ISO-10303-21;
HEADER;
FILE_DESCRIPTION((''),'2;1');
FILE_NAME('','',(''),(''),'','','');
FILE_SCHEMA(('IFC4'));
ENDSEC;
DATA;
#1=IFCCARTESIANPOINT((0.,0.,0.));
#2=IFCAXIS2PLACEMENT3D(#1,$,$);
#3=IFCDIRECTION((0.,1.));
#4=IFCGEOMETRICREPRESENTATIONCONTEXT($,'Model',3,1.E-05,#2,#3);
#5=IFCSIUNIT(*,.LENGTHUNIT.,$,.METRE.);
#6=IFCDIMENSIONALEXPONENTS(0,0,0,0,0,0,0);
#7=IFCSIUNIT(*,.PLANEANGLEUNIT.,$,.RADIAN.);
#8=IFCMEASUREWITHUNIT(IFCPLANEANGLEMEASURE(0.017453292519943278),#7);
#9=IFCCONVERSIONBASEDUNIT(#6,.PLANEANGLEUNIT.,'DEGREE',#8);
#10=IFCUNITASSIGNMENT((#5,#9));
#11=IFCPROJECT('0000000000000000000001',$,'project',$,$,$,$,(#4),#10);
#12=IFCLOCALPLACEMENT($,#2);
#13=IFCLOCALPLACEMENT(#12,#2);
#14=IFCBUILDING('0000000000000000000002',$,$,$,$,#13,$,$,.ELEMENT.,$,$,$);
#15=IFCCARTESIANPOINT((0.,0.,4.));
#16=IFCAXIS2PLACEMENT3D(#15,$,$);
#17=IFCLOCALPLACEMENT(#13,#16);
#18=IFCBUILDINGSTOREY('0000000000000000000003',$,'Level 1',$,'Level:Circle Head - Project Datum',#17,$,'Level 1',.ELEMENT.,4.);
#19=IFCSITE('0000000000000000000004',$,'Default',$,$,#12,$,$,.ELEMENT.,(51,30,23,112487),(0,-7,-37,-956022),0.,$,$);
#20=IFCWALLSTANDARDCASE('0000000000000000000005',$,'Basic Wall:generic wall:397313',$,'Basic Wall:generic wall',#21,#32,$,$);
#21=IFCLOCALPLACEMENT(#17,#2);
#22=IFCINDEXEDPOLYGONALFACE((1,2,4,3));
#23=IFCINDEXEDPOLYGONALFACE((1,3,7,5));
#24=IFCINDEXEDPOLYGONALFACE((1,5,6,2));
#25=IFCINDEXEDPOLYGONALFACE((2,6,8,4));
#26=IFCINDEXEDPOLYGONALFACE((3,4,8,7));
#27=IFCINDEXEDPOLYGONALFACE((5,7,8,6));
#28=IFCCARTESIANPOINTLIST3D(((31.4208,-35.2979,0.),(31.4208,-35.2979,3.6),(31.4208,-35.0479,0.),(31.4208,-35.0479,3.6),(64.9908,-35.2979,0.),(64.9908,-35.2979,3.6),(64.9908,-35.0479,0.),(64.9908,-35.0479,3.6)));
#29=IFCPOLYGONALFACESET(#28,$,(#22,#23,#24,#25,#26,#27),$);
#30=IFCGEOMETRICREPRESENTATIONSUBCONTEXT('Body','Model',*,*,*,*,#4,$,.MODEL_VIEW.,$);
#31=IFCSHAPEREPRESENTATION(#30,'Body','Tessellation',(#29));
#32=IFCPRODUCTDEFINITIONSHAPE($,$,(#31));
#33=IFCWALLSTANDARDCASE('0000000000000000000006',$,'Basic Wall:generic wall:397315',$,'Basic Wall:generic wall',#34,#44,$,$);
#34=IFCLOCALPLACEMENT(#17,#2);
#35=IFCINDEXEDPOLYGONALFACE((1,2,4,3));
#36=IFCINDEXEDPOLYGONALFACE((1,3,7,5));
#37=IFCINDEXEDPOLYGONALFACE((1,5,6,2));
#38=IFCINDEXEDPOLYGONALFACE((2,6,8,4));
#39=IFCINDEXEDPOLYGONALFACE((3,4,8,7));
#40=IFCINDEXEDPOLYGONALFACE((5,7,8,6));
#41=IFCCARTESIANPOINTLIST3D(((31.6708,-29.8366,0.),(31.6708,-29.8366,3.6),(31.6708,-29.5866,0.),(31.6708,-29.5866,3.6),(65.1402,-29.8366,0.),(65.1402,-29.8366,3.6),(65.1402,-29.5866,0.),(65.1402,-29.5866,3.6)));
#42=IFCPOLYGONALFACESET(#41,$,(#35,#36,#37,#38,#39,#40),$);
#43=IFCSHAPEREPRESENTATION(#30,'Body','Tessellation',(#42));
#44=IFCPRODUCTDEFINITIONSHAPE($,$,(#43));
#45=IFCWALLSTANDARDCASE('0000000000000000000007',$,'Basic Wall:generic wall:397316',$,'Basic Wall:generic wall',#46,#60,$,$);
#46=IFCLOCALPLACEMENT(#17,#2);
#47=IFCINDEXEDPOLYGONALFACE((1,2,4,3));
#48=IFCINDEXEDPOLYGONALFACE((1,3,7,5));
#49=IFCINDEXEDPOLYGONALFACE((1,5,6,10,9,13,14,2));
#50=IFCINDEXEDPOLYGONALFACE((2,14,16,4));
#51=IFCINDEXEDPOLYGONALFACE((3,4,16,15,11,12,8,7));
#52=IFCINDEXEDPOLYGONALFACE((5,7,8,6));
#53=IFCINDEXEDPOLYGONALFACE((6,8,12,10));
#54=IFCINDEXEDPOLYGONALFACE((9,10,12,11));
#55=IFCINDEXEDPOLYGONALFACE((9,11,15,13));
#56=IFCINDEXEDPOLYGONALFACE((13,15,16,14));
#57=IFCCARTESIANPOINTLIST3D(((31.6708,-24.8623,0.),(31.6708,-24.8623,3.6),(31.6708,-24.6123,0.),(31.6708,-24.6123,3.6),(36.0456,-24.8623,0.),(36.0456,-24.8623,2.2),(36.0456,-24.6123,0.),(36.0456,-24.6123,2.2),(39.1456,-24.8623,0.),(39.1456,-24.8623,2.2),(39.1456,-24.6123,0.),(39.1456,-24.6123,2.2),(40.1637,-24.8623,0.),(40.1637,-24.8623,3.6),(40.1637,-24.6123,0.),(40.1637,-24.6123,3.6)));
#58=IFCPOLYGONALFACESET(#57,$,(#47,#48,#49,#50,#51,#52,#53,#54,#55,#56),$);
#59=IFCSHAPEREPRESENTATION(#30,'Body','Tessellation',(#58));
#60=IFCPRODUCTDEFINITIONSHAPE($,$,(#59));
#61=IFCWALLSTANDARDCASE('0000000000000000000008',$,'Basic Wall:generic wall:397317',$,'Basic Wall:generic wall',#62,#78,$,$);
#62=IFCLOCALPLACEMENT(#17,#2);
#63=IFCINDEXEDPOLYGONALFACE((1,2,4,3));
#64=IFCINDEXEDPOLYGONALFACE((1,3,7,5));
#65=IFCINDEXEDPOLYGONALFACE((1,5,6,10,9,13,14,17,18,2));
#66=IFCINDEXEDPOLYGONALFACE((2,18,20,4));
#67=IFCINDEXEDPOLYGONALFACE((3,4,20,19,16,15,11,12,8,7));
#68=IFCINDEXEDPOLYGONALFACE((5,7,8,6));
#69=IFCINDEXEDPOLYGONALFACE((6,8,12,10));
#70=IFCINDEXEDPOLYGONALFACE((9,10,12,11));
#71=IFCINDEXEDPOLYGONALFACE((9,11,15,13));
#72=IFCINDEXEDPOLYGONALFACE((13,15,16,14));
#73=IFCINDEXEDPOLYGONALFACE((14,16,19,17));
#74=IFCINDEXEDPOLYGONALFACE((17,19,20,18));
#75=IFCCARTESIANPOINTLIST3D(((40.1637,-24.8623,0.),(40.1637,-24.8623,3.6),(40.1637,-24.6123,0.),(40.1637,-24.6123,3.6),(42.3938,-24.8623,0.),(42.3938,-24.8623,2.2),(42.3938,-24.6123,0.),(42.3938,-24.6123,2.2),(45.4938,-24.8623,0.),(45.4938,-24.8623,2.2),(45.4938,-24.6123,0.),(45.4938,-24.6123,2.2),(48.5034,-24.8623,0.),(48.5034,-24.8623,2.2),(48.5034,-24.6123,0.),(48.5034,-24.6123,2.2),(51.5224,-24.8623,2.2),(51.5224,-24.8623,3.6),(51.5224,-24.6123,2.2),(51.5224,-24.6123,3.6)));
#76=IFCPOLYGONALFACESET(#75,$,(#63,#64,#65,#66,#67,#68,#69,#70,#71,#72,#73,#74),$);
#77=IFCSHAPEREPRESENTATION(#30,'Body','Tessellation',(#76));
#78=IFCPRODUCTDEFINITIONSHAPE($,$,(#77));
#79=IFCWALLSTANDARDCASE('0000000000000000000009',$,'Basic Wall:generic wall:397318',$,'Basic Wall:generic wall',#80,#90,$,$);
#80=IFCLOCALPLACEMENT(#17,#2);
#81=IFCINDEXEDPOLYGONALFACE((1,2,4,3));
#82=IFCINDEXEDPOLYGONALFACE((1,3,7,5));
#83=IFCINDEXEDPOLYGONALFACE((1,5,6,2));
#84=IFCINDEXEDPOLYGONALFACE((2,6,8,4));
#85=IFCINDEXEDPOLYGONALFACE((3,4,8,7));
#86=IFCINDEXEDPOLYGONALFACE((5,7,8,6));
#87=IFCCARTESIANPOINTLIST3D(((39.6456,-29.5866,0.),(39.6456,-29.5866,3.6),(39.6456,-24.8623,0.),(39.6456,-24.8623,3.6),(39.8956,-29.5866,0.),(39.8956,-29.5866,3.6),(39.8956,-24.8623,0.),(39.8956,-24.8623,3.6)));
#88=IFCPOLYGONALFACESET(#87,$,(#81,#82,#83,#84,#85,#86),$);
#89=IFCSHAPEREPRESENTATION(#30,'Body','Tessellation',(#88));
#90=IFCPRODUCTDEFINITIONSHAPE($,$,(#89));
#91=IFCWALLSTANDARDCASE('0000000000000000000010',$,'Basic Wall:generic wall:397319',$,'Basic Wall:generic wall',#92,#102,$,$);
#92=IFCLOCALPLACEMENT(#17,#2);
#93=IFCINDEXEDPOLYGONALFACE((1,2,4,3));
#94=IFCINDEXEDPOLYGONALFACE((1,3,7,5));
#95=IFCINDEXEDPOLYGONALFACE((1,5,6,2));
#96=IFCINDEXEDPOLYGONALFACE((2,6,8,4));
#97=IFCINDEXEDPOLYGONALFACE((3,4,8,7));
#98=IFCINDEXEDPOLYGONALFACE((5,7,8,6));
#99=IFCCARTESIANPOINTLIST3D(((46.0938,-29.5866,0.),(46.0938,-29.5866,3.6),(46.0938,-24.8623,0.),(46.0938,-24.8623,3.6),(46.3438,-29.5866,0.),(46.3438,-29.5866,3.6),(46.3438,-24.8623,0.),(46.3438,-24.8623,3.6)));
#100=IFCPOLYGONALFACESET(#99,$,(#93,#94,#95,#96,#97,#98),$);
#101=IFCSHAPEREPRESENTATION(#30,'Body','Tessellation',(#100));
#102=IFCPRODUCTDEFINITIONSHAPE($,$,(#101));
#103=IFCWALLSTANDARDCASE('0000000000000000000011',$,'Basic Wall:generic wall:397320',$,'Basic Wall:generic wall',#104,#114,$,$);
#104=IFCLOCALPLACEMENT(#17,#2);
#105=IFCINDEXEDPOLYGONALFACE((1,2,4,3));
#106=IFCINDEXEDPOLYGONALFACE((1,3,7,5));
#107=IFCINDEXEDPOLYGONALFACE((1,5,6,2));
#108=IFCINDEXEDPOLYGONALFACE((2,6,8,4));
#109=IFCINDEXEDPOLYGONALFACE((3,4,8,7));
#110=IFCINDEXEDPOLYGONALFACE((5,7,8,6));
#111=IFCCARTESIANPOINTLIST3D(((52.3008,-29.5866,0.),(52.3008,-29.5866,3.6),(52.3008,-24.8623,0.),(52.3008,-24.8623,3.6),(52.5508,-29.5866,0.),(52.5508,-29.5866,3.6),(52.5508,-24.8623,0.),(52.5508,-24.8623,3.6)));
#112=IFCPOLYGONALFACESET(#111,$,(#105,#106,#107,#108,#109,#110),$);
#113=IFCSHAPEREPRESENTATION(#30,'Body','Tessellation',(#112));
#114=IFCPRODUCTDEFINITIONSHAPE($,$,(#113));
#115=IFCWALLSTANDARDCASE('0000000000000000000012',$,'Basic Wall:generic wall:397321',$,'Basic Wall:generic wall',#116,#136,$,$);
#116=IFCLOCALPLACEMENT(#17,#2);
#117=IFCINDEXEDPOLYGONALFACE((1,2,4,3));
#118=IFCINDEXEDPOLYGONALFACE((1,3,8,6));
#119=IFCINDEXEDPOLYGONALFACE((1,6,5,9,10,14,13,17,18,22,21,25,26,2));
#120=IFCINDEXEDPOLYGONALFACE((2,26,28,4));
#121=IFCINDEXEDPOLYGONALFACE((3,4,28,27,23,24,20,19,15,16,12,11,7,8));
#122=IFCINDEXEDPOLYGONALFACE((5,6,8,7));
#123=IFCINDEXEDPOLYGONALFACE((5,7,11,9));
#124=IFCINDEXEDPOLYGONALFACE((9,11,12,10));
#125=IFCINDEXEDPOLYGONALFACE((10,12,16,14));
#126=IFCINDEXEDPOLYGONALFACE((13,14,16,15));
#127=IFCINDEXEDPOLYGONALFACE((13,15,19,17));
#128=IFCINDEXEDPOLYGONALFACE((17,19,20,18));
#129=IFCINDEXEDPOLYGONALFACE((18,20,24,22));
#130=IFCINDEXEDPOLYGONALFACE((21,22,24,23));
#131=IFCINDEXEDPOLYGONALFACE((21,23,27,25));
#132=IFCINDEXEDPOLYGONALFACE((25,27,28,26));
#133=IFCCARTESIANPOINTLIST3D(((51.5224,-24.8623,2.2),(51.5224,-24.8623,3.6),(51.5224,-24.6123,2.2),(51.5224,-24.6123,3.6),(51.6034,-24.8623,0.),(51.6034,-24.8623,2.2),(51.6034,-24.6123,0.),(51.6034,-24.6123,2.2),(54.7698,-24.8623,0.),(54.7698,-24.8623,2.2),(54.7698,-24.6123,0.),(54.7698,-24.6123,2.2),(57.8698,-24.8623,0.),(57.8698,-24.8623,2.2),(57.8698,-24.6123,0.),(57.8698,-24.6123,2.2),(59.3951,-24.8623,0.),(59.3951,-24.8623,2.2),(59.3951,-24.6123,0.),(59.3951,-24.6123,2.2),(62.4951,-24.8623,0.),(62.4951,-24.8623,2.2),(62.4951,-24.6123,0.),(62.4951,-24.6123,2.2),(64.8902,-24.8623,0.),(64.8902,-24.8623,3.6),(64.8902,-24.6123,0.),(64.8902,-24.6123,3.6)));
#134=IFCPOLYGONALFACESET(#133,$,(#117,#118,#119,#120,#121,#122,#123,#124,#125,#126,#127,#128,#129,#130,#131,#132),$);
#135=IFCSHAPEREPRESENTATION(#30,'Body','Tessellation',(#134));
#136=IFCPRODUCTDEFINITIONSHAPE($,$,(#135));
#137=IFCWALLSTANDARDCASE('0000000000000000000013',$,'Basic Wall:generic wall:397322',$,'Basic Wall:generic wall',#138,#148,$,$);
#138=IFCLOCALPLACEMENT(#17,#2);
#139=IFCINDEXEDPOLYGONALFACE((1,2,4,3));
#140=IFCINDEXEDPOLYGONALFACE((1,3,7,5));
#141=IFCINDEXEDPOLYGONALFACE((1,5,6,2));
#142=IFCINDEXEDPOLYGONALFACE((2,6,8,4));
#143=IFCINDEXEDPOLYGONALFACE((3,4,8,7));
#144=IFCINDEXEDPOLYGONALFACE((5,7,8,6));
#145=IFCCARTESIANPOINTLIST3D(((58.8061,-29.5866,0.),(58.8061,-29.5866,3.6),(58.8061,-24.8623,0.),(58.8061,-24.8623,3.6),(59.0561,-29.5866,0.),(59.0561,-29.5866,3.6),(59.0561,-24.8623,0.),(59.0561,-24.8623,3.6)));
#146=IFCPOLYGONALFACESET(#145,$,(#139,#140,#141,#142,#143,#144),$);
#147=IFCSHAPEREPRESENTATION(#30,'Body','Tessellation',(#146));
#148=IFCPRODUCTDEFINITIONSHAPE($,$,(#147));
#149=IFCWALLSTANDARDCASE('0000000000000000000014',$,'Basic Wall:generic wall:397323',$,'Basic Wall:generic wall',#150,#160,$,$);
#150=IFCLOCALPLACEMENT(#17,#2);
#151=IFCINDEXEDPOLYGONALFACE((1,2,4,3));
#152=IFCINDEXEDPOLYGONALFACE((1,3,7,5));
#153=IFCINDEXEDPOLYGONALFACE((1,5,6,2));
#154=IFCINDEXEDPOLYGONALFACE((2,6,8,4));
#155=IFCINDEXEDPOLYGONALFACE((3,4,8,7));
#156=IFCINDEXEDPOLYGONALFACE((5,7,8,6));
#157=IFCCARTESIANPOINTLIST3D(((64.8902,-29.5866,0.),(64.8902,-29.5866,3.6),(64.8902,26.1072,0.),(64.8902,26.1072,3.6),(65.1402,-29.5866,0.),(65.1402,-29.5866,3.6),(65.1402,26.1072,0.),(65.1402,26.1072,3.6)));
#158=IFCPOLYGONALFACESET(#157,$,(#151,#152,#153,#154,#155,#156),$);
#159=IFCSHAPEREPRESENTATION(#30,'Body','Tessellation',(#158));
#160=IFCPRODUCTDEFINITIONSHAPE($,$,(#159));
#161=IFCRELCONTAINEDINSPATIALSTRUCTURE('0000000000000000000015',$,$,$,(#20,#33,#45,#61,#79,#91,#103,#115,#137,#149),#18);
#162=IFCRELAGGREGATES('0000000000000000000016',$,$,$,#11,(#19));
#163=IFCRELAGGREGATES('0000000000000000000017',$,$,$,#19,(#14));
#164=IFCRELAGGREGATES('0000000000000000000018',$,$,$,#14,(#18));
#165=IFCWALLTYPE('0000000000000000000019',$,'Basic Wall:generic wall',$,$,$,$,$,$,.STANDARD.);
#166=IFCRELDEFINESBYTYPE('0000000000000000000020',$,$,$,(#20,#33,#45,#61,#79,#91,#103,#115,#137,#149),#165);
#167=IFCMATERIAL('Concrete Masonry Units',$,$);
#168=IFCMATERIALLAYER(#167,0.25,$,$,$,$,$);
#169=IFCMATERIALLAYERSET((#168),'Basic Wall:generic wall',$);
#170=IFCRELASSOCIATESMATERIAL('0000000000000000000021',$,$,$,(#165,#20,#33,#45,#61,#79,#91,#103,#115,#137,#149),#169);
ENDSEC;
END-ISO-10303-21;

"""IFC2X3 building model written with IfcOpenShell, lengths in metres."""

from ifc_helpers import new_model, entity, si_unit, converted_unit, direction, frame, frame_2d, origin, place, context, subcontext, project, spatial, rectangle, extrude, material, layer, layer_set, layer_usage, type_object, element, save


model = new_model("IFC2X3")

# Units and contexts
model_context = context("Model", 3, precision=1e-05, world=origin(), true_north=direction((0.0, 1.0)))
body_context = subcontext(model_context, "Body", "Model", "MODEL_VIEW")
ifc_project = project(units=[si_unit("LENGTHUNIT", "METRE"), converted_unit("PLANEANGLEUNIT", "DEGREE", entity("IfcPlaneAngleMeasure", 0.017453292519943278), si_unit("PLANEANGLEUNIT", "RADIAN"), dimensions=[0, 0, 0, 0, 0, 0, 0])], contexts=[model_context])

# Site, building, storey
site_placement = place(None, origin())
site = spatial("IfcSite", under=ifc_project, at=site_placement, Name="Default", CompositionType="ELEMENT", RefLatitude=(51, 30, 23, 112487), RefLongitude=(0, -7, -37, -956022), RefElevation=0.0)
building_placement = place(site_placement, origin())
building = spatial("IfcBuilding", under=site, at=building_placement, CompositionType="ELEMENT")
storey_placement = place(building_placement, frame((0.0, 0.0, 4.0)))
storey = spatial("IfcBuildingStorey", under=building, at=storey_placement, Name="Level 1", ObjectType="Level:Circle Head - Project Datum", LongName="Level 1", CompositionType="ELEMENT", Elevation=4.0)

# Shared definitions
ifc_material = material(Name="Concrete Masonry Units")
ifc_layer = layer(ifc_material, 0.25)
ifc_layer_set = layer_set([ifc_layer], Name="Basic Wall:generic wall")
wall_type = type_object("IfcWallType", Name="Basic Wall:generic wall", PredefinedType="STANDARD", material=ifc_layer_set)

# Walls
ifc_layer_usage_1 = layer_usage(ifc_layer_set, "AXIS2", "NEGATIVE", 0.125)
wall_1_placement = place(storey_placement, frame((64.9908, -35.1729, 0.0), z_axis=(0.0, 0.0, 1.0), x_axis=(-1.0, 0.0, 0.0)))
element("IfcWallStandardCase", 1, at=wall_1_placement, inside=storey, type_object=wall_type, material=ifc_layer_usage_1, Name="Basic Wall:generic wall:397313", ObjectType="Basic Wall:generic wall", context=body_context, shape_type="SweptSolid", body=[
    extrude(rectangle(XDim=33.57, YDim=0.25, at=frame_2d((16.785, 0.0), x_axis=(-1.0, 0.0))), origin(), (0.0, 0.0, 1.0), 3.6),
])
ifc_layer_usage_2 = layer_usage(ifc_layer_set, "AXIS2", "NEGATIVE", 0.125)
wall_2_placement = place(storey_placement, frame((31.6708, -29.7116, 0.0)))
element("IfcWallStandardCase", 2, at=wall_2_placement, inside=storey, type_object=wall_type, material=ifc_layer_usage_2, Name="Basic Wall:generic wall:397315", ObjectType="Basic Wall:generic wall", context=body_context, shape_type="SweptSolid", body=[
    extrude(rectangle(XDim=33.4694, YDim=0.25, at=frame_2d((16.7347, 0.0), x_axis=(-1.0, 0.0))), origin(), (0.0, 0.0, 1.0), 3.6),
])

# Wall, opening
ifc_layer_usage_3 = layer_usage(ifc_layer_set, "AXIS2", "NEGATIVE", 0.125)
wall_3_placement = place(storey_placement, frame((31.6708, -24.7373, 0.0)))
wall_3 = element("IfcWallStandardCase", 3, at=wall_3_placement, inside=storey, type_object=wall_type, material=ifc_layer_usage_3, Name="Basic Wall:generic wall:397316", ObjectType="Basic Wall:generic wall", context=body_context, shape_type="SweptSolid", body=[
    extrude(rectangle(XDim=8.4929, YDim=0.25, at=frame_2d((4.2465, 0.0), x_axis=(-1.0, 0.0))), origin(), (0.0, 0.0, 1.0), 3.6),
])
opening_1_placement = place(wall_3_placement, frame((7.4748, 0.125, 0.0)))
element("IfcOpeningElement", 4, at=opening_1_placement, cuts=wall_3, ObjectType="Opening", context=body_context, shape_type="SweptSolid", body=[
    extrude(rectangle(XDim=2.2, YDim=3.1, at=frame_2d((1.1, 1.55), x_axis=(1.0, 0.0))), frame((0.0, 0.0, 0.0), z_axis=(0.0, -1.0, 0.0), x_axis=(0.0, 0.0, 1.0)), (0.0, 0.0, 1.0), 0.25),
])

# Wall, openings
ifc_layer_usage_4 = layer_usage(ifc_layer_set, "AXIS2", "NEGATIVE", 0.125)
wall_4_placement = place(storey_placement, frame((40.1637, -24.7373, 0.0)))
wall_4 = element("IfcWallStandardCase", 5, at=wall_4_placement, inside=storey, type_object=wall_type, material=ifc_layer_usage_4, Name="Basic Wall:generic wall:397317", ObjectType="Basic Wall:generic wall", context=body_context, shape_type="SweptSolid", body=[
    extrude(rectangle(XDim=11.3587, YDim=0.25, at=frame_2d((5.6794, 0.0), x_axis=(-1.0, 0.0))), origin(), (0.0, 0.0, 1.0), 3.6),
])
opening_2_placement = place(wall_4_placement, frame((11.4397, 0.125, 0.0)))
element("IfcOpeningElement", 6, at=opening_2_placement, cuts=wall_4, ObjectType="Opening", context=body_context, shape_type="SweptSolid", body=[
    extrude(rectangle(XDim=2.2, YDim=3.1, at=frame_2d((1.1, 1.55), x_axis=(1.0, 0.0))), frame((0.0, 0.0, 0.0), z_axis=(0.0, -1.0, 0.0), x_axis=(0.0, 0.0, 1.0)), (0.0, 0.0, 1.0), 0.25),
])
opening_3_placement = place(wall_4_placement, frame((5.3301, 0.125, 0.0)))
element("IfcOpeningElement", 7, at=opening_3_placement, cuts=wall_4, ObjectType="Opening", context=body_context, shape_type="SweptSolid", body=[
    extrude(rectangle(XDim=2.2, YDim=3.1, at=frame_2d((1.1, 1.55), x_axis=(1.0, 0.0))), frame((0.0, 0.0, 0.0), z_axis=(0.0, -1.0, 0.0), x_axis=(0.0, 0.0, 1.0)), (0.0, 0.0, 1.0), 0.25),
])

# Walls
ifc_layer_usage_5 = layer_usage(ifc_layer_set, "AXIS2", "NEGATIVE", 0.125)
wall_5_placement = place(storey_placement, frame((39.7706, -24.8623, 0.0), z_axis=(0.0, 0.0, 1.0), x_axis=(0.0, -1.0, 0.0)))
element("IfcWallStandardCase", 8, at=wall_5_placement, inside=storey, type_object=wall_type, material=ifc_layer_usage_5, Name="Basic Wall:generic wall:397318", ObjectType="Basic Wall:generic wall", context=body_context, shape_type="SweptSolid", body=[
    extrude(rectangle(XDim=4.7244, YDim=0.25, at=frame_2d((2.3622, 0.0), x_axis=(-1.0, 0.0))), origin(), (0.0, 0.0, 1.0), 3.6),
])
ifc_layer_usage_6 = layer_usage(ifc_layer_set, "AXIS2", "NEGATIVE", 0.125)
wall_6_placement = place(storey_placement, frame((46.2188, -24.8623, 0.0), z_axis=(0.0, 0.0, 1.0), x_axis=(0.0, -1.0, 0.0)))
element("IfcWallStandardCase", 9, at=wall_6_placement, inside=storey, type_object=wall_type, material=ifc_layer_usage_6, Name="Basic Wall:generic wall:397319", ObjectType="Basic Wall:generic wall", context=body_context, shape_type="SweptSolid", body=[
    extrude(rectangle(XDim=4.7244, YDim=0.25, at=frame_2d((2.3622, 0.0), x_axis=(-1.0, 0.0))), origin(), (0.0, 0.0, 1.0), 3.6),
])
ifc_layer_usage_7 = layer_usage(ifc_layer_set, "AXIS2", "NEGATIVE", 0.125)
wall_7_placement = place(storey_placement, frame((52.4258, -29.5866, 0.0), z_axis=(0.0, 0.0, 1.0), x_axis=(0.0, 1.0, 0.0)))
element("IfcWallStandardCase", 10, at=wall_7_placement, inside=storey, type_object=wall_type, material=ifc_layer_usage_7, Name="Basic Wall:generic wall:397320", ObjectType="Basic Wall:generic wall", context=body_context, shape_type="SweptSolid", body=[
    extrude(rectangle(XDim=4.7244, YDim=0.25, at=frame_2d((2.3622, 0.0), x_axis=(-1.0, 0.0))), origin(), (0.0, 0.0, 1.0), 3.6),
])

# Wall, openings
ifc_layer_usage_8 = layer_usage(ifc_layer_set, "AXIS2", "NEGATIVE", 0.125)
wall_8_placement = place(storey_placement, frame((51.5224, -24.7373, 0.0)))
wall_8 = element("IfcWallStandardCase", 11, at=wall_8_placement, inside=storey, type_object=wall_type, material=ifc_layer_usage_8, Name="Basic Wall:generic wall:397321", ObjectType="Basic Wall:generic wall", context=body_context, shape_type="SweptSolid", body=[
    extrude(rectangle(XDim=13.3677, YDim=0.25, at=frame_2d((6.6839, 0.0), x_axis=(-1.0, 0.0))), origin(), (0.0, 0.0, 1.0), 3.6),
])
opening_4_placement = place(wall_8_placement, origin())
element("IfcOpeningElement", 12, at=opening_4_placement, cuts=wall_8, ObjectType="Opening", context=body_context, shape_type="SweptSolid", body=[
    extrude(rectangle(XDim=2.2, YDim=3.1, at=frame_2d((0.0, 0.0), x_axis=(1.0, 0.0))), frame((-1.469, -1.399, 1.1), z_axis=(0.0, 1.0, 0.0), x_axis=(0.0, 0.0, 1.0)), (0.0, 0.0, 1.0), 3.048),
])
opening_5_placement = place(wall_8_placement, frame((10.9727, 0.125, 0.0)))
element("IfcOpeningElement", 13, at=opening_5_placement, cuts=wall_8, ObjectType="Opening", context=body_context, shape_type="SweptSolid", body=[
    extrude(rectangle(XDim=2.2, YDim=3.1, at=frame_2d((1.1, 1.55), x_axis=(1.0, 0.0))), frame((0.0, 0.0, 0.0), z_axis=(0.0, -1.0, 0.0), x_axis=(0.0, 0.0, 1.0)), (0.0, 0.0, 1.0), 0.25),
])
opening_6_placement = place(wall_8_placement, frame((6.3474, 0.125, 0.0)))
element("IfcOpeningElement", 14, at=opening_6_placement, cuts=wall_8, ObjectType="Opening", context=body_context, shape_type="SweptSolid", body=[
    extrude(rectangle(XDim=2.2, YDim=3.1, at=frame_2d((1.1, 1.55), x_axis=(1.0, 0.0))), frame((0.0, 0.0, 0.0), z_axis=(0.0, -1.0, 0.0), x_axis=(0.0, 0.0, 1.0)), (0.0, 0.0, 1.0), 0.25),
])

# Walls
ifc_layer_usage_9 = layer_usage(ifc_layer_set, "AXIS2", "NEGATIVE", 0.125)
wall_9_placement = place(storey_placement, frame((58.9311, -24.8623, 0.0), z_axis=(0.0, 0.0, 1.0), x_axis=(0.0, -1.0, 0.0)))
element("IfcWallStandardCase", 15, at=wall_9_placement, inside=storey, type_object=wall_type, material=ifc_layer_usage_9, Name="Basic Wall:generic wall:397322", ObjectType="Basic Wall:generic wall", context=body_context, shape_type="SweptSolid", body=[
    extrude(rectangle(XDim=4.7244, YDim=0.25, at=frame_2d((2.3622, 0.0), x_axis=(-1.0, 0.0))), origin(), (0.0, 0.0, 1.0), 3.6),
])
ifc_layer_usage_10 = layer_usage(ifc_layer_set, "AXIS2", "NEGATIVE", 0.125)
wall_10_placement = place(storey_placement, frame((65.0152, -29.5866, 0.0), z_axis=(0.0, 0.0, 1.0), x_axis=(0.0, 1.0, 0.0)))
element("IfcWallStandardCase", 16, at=wall_10_placement, inside=storey, type_object=wall_type, material=ifc_layer_usage_10, Name="Basic Wall:generic wall:397323", ObjectType="Basic Wall:generic wall", context=body_context, shape_type="SweptSolid", body=[
    extrude(rectangle(XDim=55.6939, YDim=0.25, at=frame_2d((27.8469, 0.0), x_axis=(-1.0, 0.0))), origin(), (0.0, 0.0, 1.0), 3.6),
])

save(model, "model.ifc")
